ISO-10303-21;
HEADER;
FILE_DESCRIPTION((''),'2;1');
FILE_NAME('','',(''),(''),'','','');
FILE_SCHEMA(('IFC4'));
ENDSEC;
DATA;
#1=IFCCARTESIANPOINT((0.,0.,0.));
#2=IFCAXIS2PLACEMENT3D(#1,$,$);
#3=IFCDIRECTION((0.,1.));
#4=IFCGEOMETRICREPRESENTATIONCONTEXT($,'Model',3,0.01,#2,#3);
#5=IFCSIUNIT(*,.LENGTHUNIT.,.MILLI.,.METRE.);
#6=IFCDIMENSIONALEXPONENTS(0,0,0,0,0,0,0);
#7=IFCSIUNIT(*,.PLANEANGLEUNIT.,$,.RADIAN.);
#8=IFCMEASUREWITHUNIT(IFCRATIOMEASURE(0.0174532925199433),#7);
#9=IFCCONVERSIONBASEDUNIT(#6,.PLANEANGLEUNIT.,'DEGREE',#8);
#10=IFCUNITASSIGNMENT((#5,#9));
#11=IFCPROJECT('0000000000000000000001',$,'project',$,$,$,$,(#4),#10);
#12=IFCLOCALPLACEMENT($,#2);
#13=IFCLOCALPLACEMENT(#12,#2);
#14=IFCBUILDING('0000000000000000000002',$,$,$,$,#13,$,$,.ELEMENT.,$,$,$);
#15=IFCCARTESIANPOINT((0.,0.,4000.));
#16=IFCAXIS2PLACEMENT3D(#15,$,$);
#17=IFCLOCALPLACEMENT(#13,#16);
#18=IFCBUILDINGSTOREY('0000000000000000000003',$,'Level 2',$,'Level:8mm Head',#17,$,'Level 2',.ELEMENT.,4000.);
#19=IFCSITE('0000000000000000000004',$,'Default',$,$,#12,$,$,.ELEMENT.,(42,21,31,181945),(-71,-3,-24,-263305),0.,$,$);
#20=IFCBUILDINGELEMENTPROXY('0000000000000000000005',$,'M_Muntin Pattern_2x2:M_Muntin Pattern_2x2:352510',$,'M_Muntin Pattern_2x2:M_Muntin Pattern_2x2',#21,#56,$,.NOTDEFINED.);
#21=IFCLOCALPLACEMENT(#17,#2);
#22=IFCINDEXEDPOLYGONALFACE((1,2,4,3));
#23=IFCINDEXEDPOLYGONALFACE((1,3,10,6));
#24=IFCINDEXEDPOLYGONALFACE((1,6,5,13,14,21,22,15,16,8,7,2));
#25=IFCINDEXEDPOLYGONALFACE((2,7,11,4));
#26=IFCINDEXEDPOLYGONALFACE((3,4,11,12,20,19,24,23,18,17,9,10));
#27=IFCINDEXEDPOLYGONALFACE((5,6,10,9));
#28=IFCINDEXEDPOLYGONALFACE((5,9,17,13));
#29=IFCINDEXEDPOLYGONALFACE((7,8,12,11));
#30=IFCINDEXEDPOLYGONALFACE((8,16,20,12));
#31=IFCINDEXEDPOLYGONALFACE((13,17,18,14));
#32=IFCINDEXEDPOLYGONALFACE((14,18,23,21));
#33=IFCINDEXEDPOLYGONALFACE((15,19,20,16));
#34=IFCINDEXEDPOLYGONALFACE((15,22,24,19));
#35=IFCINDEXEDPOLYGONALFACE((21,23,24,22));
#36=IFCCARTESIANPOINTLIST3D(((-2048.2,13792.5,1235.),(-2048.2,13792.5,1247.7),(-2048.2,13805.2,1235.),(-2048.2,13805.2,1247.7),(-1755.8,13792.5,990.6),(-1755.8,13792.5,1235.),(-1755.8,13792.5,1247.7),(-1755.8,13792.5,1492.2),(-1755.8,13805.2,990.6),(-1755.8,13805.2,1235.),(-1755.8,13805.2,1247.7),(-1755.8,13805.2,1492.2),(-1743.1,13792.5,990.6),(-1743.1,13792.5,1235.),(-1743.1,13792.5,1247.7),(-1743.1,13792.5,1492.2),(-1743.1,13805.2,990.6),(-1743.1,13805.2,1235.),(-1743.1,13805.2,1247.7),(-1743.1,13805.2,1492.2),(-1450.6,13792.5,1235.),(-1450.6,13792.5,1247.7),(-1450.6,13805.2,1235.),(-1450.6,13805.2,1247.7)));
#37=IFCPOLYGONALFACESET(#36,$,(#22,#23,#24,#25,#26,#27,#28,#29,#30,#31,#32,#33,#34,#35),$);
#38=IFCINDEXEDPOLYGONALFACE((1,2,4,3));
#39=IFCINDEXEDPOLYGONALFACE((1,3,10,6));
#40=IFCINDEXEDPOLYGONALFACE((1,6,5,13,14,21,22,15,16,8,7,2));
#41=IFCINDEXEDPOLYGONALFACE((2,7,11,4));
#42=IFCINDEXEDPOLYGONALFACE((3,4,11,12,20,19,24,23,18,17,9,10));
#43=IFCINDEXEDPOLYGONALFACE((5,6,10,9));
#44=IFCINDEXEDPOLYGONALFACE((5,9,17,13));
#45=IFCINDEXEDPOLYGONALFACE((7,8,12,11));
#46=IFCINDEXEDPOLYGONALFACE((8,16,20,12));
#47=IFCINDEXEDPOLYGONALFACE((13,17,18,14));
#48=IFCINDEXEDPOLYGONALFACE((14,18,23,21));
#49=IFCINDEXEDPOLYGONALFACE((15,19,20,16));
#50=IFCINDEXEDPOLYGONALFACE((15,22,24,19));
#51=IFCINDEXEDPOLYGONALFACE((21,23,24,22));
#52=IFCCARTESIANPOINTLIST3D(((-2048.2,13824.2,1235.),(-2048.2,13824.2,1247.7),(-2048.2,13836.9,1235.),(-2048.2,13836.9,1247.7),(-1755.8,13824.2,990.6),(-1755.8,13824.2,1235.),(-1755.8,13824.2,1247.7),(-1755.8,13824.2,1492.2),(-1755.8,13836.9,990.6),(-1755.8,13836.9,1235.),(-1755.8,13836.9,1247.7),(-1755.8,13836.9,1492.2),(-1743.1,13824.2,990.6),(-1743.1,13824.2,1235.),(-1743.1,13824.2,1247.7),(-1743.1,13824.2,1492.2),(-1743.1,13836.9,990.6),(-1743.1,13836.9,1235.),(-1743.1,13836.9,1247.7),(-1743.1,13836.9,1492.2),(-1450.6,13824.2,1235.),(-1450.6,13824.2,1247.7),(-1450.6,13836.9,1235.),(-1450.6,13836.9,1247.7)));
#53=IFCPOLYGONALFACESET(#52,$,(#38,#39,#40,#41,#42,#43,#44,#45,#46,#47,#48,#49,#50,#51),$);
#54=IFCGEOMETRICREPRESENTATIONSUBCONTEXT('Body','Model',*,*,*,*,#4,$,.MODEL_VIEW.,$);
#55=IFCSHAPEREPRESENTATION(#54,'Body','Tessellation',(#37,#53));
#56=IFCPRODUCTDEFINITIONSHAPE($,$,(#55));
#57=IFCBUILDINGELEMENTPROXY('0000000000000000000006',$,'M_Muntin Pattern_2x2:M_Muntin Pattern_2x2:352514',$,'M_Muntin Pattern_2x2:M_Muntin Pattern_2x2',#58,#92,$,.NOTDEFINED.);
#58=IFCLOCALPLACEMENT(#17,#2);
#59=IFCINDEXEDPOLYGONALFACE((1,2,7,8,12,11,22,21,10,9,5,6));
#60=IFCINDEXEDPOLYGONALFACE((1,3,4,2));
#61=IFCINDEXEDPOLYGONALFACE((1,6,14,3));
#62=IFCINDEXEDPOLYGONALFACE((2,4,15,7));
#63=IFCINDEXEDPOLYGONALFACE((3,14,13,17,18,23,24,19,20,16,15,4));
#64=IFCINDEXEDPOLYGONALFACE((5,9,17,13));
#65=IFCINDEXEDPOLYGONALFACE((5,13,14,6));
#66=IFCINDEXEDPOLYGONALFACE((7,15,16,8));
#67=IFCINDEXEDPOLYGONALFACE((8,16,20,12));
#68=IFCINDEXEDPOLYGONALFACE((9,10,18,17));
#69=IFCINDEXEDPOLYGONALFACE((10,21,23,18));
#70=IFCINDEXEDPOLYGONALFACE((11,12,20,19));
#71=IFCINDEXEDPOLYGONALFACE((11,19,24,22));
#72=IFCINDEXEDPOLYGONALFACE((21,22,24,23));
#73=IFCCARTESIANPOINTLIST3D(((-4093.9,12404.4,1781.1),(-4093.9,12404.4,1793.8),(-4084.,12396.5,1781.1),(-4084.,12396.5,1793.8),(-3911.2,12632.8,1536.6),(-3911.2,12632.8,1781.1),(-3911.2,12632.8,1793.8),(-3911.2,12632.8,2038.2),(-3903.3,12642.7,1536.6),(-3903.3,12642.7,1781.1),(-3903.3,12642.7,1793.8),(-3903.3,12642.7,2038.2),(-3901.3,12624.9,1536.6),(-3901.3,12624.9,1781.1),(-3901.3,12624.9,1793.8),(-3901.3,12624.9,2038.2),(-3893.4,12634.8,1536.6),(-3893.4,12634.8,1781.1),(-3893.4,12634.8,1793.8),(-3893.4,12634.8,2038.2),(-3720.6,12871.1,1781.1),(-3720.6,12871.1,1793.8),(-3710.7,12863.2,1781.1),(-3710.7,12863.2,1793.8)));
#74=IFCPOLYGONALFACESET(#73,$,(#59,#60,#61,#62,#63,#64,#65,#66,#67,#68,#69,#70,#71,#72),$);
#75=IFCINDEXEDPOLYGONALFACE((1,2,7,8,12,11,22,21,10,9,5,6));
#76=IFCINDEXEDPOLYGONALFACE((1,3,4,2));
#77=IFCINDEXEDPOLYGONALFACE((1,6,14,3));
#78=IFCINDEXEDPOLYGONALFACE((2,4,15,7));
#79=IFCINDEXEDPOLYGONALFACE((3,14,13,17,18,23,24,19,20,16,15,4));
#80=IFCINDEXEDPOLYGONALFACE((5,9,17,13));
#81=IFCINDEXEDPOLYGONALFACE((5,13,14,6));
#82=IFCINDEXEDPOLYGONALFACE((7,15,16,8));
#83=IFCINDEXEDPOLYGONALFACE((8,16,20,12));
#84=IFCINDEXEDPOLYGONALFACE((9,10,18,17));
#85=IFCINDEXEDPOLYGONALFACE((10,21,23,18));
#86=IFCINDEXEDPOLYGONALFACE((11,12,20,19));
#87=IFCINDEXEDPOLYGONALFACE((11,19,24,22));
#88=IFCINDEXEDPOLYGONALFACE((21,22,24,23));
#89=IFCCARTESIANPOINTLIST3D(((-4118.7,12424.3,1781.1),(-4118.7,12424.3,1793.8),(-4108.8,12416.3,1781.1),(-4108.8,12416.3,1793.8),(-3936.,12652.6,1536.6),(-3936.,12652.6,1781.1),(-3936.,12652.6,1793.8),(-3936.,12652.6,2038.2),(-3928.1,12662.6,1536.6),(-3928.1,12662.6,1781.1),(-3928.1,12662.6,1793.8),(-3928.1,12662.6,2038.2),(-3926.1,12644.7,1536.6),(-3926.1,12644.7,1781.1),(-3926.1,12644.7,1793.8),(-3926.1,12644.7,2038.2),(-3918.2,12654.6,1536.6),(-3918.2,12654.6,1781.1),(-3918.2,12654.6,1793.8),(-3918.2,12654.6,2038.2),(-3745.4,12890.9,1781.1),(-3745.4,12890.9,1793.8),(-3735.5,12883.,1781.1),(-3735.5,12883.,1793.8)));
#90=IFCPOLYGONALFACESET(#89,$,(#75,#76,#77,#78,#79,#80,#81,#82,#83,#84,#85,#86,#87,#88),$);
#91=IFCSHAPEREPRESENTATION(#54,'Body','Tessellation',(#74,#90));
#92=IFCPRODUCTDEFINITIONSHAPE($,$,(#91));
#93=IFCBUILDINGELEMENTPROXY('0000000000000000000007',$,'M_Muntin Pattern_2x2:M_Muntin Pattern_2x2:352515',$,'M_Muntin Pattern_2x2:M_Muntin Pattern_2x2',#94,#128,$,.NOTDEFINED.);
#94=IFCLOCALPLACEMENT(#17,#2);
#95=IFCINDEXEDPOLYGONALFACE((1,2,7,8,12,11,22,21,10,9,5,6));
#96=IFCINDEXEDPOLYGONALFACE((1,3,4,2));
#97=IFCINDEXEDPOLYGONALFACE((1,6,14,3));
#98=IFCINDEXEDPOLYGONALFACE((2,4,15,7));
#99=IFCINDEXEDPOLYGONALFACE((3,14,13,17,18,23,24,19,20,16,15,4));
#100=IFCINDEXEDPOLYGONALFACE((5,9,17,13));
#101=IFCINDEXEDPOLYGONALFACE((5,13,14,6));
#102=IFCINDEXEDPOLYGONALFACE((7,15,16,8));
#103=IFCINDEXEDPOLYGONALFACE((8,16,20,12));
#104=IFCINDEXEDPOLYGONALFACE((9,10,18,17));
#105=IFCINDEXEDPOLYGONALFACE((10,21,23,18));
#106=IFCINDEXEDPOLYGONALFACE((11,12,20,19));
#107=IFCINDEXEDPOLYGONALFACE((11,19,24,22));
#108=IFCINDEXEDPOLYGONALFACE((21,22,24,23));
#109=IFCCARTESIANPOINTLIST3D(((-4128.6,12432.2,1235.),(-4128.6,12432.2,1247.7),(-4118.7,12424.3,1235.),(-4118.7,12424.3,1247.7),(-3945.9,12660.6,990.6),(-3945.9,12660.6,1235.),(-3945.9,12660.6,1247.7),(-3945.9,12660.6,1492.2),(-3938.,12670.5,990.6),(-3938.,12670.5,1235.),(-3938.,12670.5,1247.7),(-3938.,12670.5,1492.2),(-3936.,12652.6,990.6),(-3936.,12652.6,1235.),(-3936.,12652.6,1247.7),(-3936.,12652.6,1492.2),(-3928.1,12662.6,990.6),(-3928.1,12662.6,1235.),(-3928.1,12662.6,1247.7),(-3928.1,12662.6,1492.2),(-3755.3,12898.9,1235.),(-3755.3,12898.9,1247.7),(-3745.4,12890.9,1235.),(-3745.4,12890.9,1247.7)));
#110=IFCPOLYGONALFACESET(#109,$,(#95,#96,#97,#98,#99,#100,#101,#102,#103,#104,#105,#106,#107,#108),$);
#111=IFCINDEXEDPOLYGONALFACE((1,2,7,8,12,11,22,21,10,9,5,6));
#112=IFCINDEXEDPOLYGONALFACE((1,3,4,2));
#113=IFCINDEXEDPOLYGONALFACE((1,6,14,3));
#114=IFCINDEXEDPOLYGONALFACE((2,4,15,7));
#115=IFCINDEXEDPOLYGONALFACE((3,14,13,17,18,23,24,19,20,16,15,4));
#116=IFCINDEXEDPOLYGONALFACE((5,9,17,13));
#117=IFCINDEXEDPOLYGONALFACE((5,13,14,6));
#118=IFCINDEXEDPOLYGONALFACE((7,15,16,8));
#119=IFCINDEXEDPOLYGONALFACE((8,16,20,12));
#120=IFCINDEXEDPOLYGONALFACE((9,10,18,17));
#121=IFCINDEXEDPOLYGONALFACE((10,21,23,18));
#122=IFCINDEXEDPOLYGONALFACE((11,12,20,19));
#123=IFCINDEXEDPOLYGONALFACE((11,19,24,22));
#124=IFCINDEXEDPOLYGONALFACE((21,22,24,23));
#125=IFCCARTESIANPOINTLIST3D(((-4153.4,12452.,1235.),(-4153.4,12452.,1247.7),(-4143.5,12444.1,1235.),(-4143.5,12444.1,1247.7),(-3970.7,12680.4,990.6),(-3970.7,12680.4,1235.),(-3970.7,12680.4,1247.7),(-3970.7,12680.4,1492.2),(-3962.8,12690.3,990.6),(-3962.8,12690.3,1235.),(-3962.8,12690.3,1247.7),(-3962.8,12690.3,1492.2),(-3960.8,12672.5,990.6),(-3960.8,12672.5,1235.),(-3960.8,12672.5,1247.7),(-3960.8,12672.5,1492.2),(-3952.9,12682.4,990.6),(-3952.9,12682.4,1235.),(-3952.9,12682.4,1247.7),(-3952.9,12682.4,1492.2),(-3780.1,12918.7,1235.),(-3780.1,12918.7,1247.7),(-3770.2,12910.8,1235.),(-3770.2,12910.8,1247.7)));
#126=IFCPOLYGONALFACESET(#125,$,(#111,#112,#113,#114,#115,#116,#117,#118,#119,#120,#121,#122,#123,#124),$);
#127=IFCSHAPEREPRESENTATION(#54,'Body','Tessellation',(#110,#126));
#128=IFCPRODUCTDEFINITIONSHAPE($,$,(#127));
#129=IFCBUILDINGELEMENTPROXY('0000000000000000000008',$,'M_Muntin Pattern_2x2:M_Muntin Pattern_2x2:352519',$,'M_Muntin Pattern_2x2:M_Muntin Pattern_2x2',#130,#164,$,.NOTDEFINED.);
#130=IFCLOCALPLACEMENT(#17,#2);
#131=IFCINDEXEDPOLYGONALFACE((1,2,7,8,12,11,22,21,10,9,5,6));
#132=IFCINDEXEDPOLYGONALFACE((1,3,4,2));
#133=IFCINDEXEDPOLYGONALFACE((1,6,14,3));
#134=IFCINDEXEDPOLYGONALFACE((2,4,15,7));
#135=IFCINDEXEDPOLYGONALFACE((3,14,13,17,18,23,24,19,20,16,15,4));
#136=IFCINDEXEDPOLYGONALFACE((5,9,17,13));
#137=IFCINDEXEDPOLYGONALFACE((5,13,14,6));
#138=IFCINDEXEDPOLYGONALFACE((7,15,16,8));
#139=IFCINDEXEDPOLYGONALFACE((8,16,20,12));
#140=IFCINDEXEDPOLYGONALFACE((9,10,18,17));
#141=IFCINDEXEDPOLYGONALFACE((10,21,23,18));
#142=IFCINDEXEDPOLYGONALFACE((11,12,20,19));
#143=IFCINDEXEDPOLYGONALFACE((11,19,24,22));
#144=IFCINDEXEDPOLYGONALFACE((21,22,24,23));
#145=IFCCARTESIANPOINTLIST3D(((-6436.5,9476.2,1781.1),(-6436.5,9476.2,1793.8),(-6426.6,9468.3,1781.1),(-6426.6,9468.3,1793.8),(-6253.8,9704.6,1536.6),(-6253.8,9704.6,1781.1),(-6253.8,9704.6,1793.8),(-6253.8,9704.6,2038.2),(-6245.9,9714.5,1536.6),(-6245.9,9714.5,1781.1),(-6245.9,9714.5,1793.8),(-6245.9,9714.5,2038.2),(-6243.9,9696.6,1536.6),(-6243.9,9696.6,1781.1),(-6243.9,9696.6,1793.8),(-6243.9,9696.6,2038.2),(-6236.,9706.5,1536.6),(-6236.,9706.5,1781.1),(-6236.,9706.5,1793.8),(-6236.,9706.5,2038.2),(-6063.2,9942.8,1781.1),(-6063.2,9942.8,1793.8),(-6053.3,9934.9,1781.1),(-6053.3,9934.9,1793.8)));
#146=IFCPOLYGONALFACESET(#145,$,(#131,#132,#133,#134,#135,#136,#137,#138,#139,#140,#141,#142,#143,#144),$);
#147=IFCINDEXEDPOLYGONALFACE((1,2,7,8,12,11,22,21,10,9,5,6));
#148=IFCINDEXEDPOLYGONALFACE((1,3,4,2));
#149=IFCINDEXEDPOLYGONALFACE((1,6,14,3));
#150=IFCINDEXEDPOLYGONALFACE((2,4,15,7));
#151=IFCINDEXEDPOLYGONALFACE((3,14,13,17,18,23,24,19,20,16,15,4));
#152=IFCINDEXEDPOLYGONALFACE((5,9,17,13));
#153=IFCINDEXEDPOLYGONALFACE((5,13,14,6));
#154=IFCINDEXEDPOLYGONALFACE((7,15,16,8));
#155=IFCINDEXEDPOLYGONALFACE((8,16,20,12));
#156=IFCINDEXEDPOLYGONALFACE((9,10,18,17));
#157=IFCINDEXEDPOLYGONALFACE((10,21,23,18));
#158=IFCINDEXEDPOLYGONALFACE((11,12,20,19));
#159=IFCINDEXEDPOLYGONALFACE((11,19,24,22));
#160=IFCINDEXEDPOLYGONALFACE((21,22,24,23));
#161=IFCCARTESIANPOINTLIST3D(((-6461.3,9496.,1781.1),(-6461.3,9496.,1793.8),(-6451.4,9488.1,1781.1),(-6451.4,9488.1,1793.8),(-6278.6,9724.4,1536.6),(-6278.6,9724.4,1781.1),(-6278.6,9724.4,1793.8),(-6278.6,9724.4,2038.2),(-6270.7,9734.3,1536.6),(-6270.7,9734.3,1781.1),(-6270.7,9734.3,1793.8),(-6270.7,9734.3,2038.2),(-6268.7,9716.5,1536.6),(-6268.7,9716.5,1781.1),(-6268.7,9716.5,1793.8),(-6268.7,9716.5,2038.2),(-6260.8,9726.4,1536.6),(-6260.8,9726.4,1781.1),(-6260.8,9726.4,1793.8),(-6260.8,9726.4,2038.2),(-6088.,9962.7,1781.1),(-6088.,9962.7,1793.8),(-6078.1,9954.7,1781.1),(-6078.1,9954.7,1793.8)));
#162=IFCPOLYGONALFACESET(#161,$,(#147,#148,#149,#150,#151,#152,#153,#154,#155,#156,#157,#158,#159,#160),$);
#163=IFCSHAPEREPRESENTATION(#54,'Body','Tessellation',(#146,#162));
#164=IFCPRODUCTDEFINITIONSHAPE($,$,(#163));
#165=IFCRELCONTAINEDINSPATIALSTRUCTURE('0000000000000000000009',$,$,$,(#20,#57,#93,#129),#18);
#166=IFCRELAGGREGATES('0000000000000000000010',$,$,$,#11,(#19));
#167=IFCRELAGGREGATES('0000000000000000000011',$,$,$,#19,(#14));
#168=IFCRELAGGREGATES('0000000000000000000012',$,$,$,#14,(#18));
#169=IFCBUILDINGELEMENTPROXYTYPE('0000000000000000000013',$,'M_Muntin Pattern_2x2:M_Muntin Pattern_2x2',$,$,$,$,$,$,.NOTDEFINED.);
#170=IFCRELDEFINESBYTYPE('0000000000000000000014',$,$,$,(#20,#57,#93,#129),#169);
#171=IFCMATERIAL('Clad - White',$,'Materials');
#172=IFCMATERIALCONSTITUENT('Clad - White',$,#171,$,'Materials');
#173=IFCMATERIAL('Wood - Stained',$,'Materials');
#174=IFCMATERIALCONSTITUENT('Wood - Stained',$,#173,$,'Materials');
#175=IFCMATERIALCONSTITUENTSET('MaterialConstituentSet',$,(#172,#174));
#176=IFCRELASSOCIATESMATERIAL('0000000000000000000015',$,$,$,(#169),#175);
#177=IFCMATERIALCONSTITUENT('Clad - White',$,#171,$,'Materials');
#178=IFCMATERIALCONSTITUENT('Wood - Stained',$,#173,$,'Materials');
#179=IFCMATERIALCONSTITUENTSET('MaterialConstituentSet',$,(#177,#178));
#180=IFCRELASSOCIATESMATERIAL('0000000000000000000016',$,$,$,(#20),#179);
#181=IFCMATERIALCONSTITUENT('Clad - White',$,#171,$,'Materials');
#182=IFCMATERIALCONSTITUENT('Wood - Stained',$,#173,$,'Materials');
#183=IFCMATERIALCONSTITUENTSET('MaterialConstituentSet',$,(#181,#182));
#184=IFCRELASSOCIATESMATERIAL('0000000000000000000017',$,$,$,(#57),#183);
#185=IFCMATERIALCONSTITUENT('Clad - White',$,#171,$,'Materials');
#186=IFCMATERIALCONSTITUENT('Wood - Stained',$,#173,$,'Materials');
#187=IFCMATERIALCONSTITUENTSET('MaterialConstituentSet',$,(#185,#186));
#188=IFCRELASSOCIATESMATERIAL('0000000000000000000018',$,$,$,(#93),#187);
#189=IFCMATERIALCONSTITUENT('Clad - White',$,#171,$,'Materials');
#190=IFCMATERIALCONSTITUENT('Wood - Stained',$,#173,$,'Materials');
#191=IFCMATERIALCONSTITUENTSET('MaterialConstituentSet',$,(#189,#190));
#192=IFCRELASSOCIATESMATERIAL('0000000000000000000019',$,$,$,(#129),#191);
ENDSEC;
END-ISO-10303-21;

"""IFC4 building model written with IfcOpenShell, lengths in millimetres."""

from ifc_helpers import new_model, entity, si_unit, converted_unit, direction, frame, origin, place, context, subcontext, project, spatial, polyline, outline, extrude, source, transform, mapped, material, constituent, constituent_set, type_object, type_shapes, element, save


model = new_model("IFC4")

# Units and contexts
model_context = context("Model", 3, precision=0.01, world=origin(), true_north=direction((0.0, 1.0)))
body_context = subcontext(model_context, "Body", "Model", "MODEL_VIEW")
ifc_project = project(units=[si_unit("LENGTHUNIT", "METRE", prefix="MILLI"), converted_unit("PLANEANGLEUNIT", "DEGREE", entity("IfcRatioMeasure", 0.0174532925199433), si_unit("PLANEANGLEUNIT", "RADIAN"), dimensions=[0, 0, 0, 0, 0, 0, 0])], contexts=[model_context])

# Site, building, storey
site_placement = place(None, origin())
site = spatial("IfcSite", under=ifc_project, at=site_placement, Name="Default", CompositionType="ELEMENT", RefLatitude=(42, 21, 31, 181945), RefLongitude=(-71, -3, -24, -263305), RefElevation=0.0)
building_placement = place(site_placement, origin())
building = spatial("IfcBuilding", under=site, at=building_placement, CompositionType="ELEMENT")
storey_placement = place(building_placement, frame((0.0, 0.0, 4000.0)))
storey = spatial("IfcBuildingStorey", under=building, at=storey_placement, Name="Level 2", ObjectType="Level:8mm Head", LongName="Level 2", CompositionType="ELEMENT", Elevation=4000.0)

# Shared definitions
ifc_material_1 = material(Name="Wood - Stained", Category="Materials")

# Building element proxies
ifc_material_2 = material(Name="Clad - White", Category="Materials")
ifc_constituent_1 = constituent(ifc_material_2, Name="Clad - White", Category="Materials")
ifc_constituent_2 = constituent(ifc_material_1, Name="Wood - Stained", Category="Materials")
ifc_constituent_set_1 = constituent_set(constituents=[ifc_constituent_1, ifc_constituent_2], Name="MaterialConstituentSet")
building_element_proxy_type_1 = type_object("IfcBuildingElementProxyType", Name="M_Muntin Pattern_2x2:M_Muntin Pattern_2x2", PredefinedType="NOTDEFINED", material=ifc_constituent_set_1)
shared_shape_1 = source(origin(), body_context, "Body", "SweptSolid", [
    extrude(outline(polyline([(6.4, -6.4), (250.8, -6.4), (250.8, 6.3), (6.4, 6.3), (6.4, 298.8), (-6.3, 298.8), (-6.3, 6.3), (-250.8, 6.3), (-250.8, -6.4), (-6.3, -6.4), (-6.3, -298.8), (6.4, -298.8), (6.4, -6.4)])), frame((0.0, 9.5, 250.8), z_axis=(0.0, 1.0, 0.0), x_axis=(0.0, 0.0, 1.0)), (0.0, 0.0, 1.0), 12.7),
    extrude(outline(polyline([(6.4, -6.4), (250.8, -6.4), (250.8, 6.3), (6.4, 6.3), (6.4, 298.8), (-6.3, 298.8), (-6.3, 6.3), (-250.8, 6.3), (-250.8, -6.4), (-6.3, -6.4), (-6.3, -298.8), (6.4, -298.8), (6.4, -6.4)])), frame((0.0, -22.2, 250.8), z_axis=(0.0, 1.0, 0.0), x_axis=(0.0, 0.0, 1.0)), (0.0, 0.0, 1.0), 12.7),
])
type_shapes(building_element_proxy_type_1, [shared_shape_1])
ifc_constituent_3 = constituent(ifc_material_2, Name="Clad - White", Category="Materials")
ifc_constituent_4 = constituent(ifc_material_1, Name="Wood - Stained", Category="Materials")
ifc_constituent_set_2 = constituent_set(constituents=[ifc_constituent_3, ifc_constituent_4], Name="MaterialConstituentSet")
proxy_1_placement = place(storey_placement, frame((-1749.4, 13814.7, 990.6), z_axis=(0.0, 0.0, 1.0), x_axis=(-1.0, 0.0, 0.0)))
element("IfcBuildingElementProxy", 1, at=proxy_1_placement, inside=storey, type_object=building_element_proxy_type_1, material=ifc_constituent_set_2, Name="M_Muntin Pattern_2x2:M_Muntin Pattern_2x2:352510", ObjectType="M_Muntin Pattern_2x2:M_Muntin Pattern_2x2", PredefinedType="NOTDEFINED", context=body_context, shape_type="MappedRepresentation", body=[
    mapped(shared_shape_1, transform((0.0, 0.0, 0.0), scale=1.0)),
])
ifc_constituent_5 = constituent(ifc_material_2, Name="Clad - White", Category="Materials")
ifc_constituent_6 = constituent(ifc_material_1, Name="Wood - Stained", Category="Materials")
ifc_constituent_set_3 = constituent_set(constituents=[ifc_constituent_5, ifc_constituent_6], Name="MaterialConstituentSet")
proxy_2_placement = place(storey_placement, frame((-3914.7, 12643.7, 1536.6), z_axis=(0.0, 0.0, 1.0), x_axis=(-0.624695, -0.780869, 0.0)))
element("IfcBuildingElementProxy", 2, at=proxy_2_placement, inside=storey, type_object=building_element_proxy_type_1, material=ifc_constituent_set_3, Name="M_Muntin Pattern_2x2:M_Muntin Pattern_2x2:352514", ObjectType="M_Muntin Pattern_2x2:M_Muntin Pattern_2x2", PredefinedType="NOTDEFINED", context=body_context, shape_type="MappedRepresentation", body=[
    mapped(shared_shape_1, transform((0.0, 0.0, 0.0), scale=1.0)),
])
ifc_constituent_7 = constituent(ifc_material_2, Name="Clad - White", Category="Materials")
ifc_constituent_8 = constituent(ifc_material_1, Name="Wood - Stained", Category="Materials")
ifc_constituent_set_4 = constituent_set(constituents=[ifc_constituent_7, ifc_constituent_8], Name="MaterialConstituentSet")
proxy_3_placement = place(storey_placement, frame((-3949.4, 12671.5, 990.6), z_axis=(0.0, 0.0, 1.0), x_axis=(-0.624695, -0.780869, 0.0)))
element("IfcBuildingElementProxy", 3, at=proxy_3_placement, inside=storey, type_object=building_element_proxy_type_1, material=ifc_constituent_set_4, Name="M_Muntin Pattern_2x2:M_Muntin Pattern_2x2:352515", ObjectType="M_Muntin Pattern_2x2:M_Muntin Pattern_2x2", PredefinedType="NOTDEFINED", context=body_context, shape_type="MappedRepresentation", body=[
    mapped(shared_shape_1, transform((0.0, 0.0, 0.0), scale=1.0)),
])
ifc_constituent_9 = constituent(ifc_material_2, Name="Clad - White", Category="Materials")
ifc_constituent_10 = constituent(ifc_material_1, Name="Wood - Stained", Category="Materials")
ifc_constituent_set_5 = constituent_set(constituents=[ifc_constituent_9, ifc_constituent_10], Name="MaterialConstituentSet")
proxy_4_placement = place(storey_placement, frame((-6257.3, 9715.5, 1536.6), z_axis=(0.0, 0.0, 1.0), x_axis=(-0.624695, -0.780869, 0.0)))
element("IfcBuildingElementProxy", 4, at=proxy_4_placement, inside=storey, type_object=building_element_proxy_type_1, material=ifc_constituent_set_5, Name="M_Muntin Pattern_2x2:M_Muntin Pattern_2x2:352519", ObjectType="M_Muntin Pattern_2x2:M_Muntin Pattern_2x2", PredefinedType="NOTDEFINED", context=body_context, shape_type="MappedRepresentation", body=[
    mapped(shared_shape_1, transform((0.0, 0.0, 0.0), scale=1.0)),
])

save(model, "model.ifc")
